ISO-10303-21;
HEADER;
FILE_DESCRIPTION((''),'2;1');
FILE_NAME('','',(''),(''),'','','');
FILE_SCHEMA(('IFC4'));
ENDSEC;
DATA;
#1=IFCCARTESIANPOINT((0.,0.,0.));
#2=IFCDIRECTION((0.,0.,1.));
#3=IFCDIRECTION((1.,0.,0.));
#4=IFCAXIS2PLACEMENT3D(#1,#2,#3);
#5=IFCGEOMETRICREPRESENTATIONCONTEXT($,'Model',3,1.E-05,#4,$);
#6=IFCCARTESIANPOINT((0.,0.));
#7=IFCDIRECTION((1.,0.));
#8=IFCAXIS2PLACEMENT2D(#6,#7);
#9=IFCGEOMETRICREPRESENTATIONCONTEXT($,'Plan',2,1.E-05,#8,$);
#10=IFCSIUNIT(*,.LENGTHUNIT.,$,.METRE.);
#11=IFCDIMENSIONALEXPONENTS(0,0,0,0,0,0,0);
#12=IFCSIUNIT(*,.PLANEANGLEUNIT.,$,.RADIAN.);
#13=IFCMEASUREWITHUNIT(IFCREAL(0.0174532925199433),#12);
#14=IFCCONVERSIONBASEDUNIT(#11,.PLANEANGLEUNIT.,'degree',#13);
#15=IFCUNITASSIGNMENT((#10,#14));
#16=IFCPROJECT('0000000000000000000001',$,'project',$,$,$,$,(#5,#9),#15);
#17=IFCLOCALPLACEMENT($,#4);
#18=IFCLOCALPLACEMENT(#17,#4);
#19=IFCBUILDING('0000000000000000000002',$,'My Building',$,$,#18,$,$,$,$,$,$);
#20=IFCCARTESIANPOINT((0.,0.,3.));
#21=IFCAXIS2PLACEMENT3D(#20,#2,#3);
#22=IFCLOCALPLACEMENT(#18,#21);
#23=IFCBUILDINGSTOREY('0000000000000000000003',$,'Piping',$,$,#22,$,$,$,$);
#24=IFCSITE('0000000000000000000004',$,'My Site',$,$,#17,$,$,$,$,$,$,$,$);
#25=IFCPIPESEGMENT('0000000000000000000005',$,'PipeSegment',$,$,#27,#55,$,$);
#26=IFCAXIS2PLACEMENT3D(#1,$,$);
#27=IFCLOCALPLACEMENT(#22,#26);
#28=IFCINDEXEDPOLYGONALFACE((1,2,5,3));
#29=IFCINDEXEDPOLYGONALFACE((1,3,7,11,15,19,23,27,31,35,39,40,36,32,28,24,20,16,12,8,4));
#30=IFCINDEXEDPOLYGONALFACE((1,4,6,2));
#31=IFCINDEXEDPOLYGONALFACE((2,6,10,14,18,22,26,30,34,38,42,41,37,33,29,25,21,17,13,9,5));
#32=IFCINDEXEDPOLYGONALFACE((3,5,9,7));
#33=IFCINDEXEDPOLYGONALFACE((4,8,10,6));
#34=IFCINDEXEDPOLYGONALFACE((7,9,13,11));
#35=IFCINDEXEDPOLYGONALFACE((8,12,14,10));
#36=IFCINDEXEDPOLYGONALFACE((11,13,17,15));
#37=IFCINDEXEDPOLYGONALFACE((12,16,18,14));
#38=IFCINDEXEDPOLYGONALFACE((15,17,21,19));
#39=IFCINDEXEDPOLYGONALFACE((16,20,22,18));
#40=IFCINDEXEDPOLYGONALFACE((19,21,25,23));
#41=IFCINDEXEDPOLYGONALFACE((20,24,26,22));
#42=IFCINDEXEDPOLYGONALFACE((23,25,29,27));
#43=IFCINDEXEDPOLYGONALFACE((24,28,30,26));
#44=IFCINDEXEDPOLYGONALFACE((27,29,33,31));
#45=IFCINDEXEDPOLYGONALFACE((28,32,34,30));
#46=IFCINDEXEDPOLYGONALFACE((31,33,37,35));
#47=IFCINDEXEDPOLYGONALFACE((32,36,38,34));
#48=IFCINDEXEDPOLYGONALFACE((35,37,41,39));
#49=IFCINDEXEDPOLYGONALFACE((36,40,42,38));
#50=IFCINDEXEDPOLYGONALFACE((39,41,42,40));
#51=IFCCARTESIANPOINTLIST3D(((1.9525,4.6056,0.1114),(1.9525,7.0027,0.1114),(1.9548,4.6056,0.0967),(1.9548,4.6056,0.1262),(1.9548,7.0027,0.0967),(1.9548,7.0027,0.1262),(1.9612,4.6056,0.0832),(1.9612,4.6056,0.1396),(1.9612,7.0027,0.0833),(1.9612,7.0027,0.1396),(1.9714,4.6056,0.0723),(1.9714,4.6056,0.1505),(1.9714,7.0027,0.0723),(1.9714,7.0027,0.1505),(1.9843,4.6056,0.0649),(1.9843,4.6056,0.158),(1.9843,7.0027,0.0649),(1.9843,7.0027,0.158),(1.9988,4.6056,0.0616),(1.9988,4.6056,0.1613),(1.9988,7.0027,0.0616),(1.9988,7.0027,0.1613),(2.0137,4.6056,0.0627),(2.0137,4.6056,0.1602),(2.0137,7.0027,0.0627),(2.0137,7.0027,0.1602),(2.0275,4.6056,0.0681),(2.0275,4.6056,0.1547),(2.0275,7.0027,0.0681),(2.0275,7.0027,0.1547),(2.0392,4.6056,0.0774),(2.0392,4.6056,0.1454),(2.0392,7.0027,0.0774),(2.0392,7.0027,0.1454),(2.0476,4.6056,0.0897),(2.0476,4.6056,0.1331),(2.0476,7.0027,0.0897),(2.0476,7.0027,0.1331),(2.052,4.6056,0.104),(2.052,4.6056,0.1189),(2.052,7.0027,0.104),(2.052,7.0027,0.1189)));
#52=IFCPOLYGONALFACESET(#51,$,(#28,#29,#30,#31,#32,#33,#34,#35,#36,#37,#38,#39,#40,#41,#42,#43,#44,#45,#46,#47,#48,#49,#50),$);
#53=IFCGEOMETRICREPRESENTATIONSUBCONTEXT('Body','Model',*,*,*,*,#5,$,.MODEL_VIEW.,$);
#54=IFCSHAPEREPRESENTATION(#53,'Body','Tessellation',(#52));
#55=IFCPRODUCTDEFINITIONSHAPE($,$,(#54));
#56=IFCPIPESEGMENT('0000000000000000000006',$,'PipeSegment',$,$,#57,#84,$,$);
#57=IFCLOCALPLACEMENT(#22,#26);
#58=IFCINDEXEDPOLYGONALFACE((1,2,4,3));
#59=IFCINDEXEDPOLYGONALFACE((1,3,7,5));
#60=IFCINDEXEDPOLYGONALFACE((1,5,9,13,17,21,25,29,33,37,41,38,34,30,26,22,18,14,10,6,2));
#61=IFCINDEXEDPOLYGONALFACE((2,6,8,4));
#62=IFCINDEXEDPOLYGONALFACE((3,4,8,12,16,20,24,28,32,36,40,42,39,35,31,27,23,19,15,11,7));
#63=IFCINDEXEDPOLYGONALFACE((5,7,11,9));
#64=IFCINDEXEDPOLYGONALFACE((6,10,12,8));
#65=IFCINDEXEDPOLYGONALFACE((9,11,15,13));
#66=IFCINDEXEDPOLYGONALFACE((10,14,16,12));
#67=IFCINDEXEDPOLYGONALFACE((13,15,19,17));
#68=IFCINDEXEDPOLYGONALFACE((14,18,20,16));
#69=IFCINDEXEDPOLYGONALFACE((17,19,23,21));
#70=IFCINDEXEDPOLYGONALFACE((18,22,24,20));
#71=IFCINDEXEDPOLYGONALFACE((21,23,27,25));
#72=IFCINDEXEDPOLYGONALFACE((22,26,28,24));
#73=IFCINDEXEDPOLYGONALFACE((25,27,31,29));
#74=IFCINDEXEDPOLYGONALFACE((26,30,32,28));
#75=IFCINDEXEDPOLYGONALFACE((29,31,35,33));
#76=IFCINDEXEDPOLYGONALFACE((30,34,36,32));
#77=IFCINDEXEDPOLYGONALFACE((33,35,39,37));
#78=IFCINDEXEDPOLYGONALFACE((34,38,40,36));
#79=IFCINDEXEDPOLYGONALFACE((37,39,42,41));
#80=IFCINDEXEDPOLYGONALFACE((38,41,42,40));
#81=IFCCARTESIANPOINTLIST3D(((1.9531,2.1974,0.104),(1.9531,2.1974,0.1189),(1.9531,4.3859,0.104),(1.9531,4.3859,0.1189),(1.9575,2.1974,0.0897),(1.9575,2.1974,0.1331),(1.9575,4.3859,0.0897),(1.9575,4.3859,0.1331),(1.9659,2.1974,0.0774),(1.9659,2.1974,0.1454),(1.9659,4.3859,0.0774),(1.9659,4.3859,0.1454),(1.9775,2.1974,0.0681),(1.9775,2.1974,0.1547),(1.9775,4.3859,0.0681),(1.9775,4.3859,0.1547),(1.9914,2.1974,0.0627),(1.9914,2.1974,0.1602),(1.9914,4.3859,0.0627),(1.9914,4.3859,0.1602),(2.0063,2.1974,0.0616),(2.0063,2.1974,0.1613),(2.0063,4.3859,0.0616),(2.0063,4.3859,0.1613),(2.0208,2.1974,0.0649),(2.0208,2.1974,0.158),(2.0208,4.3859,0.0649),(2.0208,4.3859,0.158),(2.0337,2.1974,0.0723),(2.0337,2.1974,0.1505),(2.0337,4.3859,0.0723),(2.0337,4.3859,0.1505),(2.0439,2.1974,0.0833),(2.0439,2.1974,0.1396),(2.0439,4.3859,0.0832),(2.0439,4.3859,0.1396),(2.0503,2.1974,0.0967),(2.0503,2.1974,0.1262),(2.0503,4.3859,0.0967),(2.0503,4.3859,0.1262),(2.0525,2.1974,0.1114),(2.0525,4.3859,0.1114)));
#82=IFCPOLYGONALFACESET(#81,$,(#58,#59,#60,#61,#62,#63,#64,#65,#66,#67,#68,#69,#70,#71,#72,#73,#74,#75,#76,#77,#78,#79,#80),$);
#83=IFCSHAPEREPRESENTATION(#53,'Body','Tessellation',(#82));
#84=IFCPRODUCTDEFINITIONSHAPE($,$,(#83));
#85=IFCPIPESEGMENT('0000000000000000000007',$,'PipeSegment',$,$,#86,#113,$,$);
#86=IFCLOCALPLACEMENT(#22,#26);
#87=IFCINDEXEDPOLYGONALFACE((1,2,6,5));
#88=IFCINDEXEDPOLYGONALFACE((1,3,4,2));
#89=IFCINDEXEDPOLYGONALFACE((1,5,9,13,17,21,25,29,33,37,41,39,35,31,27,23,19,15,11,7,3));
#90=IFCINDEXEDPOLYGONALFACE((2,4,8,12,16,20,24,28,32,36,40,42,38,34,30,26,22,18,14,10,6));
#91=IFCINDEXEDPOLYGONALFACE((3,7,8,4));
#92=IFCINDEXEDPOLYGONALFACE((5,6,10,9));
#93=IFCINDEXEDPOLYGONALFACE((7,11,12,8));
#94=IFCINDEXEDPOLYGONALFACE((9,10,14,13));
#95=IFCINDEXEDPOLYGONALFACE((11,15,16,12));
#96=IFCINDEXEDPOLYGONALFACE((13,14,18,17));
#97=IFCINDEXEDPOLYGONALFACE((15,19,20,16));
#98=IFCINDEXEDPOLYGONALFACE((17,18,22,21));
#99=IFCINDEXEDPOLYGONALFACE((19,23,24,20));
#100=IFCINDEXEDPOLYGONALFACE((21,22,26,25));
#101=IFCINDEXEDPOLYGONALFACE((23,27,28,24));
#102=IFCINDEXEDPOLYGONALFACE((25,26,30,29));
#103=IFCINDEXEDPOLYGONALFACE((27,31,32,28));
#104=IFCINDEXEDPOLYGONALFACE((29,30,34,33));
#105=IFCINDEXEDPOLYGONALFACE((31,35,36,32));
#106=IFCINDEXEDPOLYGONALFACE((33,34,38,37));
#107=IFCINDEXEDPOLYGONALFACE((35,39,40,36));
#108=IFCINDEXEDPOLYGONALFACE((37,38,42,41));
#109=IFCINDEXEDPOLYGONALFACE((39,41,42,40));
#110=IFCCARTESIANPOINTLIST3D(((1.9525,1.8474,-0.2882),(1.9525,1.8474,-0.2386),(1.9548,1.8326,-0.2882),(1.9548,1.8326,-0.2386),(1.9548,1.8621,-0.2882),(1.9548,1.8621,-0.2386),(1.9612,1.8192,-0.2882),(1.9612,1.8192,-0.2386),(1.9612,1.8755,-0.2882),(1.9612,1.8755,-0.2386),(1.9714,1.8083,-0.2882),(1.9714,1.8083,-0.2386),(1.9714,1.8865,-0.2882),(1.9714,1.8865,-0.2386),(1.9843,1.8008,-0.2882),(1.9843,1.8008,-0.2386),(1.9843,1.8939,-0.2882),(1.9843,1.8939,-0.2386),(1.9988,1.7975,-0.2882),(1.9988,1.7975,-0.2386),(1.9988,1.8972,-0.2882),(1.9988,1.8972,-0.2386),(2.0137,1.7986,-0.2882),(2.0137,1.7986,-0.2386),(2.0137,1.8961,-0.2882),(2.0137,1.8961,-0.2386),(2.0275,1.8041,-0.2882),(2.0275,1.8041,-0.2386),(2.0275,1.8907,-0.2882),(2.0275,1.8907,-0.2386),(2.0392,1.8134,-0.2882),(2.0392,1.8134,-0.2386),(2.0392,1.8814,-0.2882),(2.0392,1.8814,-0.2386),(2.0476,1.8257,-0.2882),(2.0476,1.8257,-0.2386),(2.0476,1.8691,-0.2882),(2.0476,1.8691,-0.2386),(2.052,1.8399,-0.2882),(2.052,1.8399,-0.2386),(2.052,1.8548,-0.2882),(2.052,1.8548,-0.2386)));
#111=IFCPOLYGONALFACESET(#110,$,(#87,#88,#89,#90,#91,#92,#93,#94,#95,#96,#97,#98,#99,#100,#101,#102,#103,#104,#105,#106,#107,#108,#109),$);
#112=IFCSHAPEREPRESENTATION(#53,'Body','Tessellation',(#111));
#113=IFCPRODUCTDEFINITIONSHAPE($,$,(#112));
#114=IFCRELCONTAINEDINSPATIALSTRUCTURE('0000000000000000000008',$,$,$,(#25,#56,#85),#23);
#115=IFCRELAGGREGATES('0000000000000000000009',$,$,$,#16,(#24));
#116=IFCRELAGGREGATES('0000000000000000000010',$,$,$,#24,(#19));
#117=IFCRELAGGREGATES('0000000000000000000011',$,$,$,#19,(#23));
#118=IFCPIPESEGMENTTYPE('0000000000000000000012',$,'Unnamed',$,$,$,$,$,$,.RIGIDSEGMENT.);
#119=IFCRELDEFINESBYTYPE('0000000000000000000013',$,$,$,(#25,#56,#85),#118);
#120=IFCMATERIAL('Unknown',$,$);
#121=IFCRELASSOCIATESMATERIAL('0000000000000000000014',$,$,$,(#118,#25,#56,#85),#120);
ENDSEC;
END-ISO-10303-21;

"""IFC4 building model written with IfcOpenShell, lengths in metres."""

from ifc_helpers import new_model, entity, si_unit, converted_unit, frame, origin_with_axes, origin_2d_with_axis, place, context, subcontext, project, spatial, circle, extrude, material, material_profile, profile_set, profile_usage, type_object, element, save


model = new_model("IFC4")

# Units and contexts
model_context = context("Model", 3, precision=1e-05, world=origin_with_axes())
plan_context = context("Plan", 2, precision=1e-05, world=origin_2d_with_axis())
body_context = subcontext(model_context, "Body", "Model", "MODEL_VIEW")
ifc_project = project(units=[si_unit("LENGTHUNIT", "METRE"), converted_unit("PLANEANGLEUNIT", "degree", entity("IfcReal", 0.0174532925199433), si_unit("PLANEANGLEUNIT", "RADIAN"), dimensions=[0, 0, 0, 0, 0, 0, 0])], contexts=[model_context, plan_context])

# Site, building, storey
site_placement = place(None, origin_with_axes())
site = spatial("IfcSite", under=ifc_project, at=site_placement, Name="My Site")
building_placement = place(site_placement, origin_with_axes())
building = spatial("IfcBuilding", under=site, at=building_placement, Name="My Building")
storey_placement = place(building_placement, frame((0.0, 0.0, 3.0), z_axis=(0.0, 0.0, 1.0), x_axis=(1.0, 0.0, 0.0)))
storey = spatial("IfcBuildingStorey", under=building, at=storey_placement, Name="Piping")

# Pipe segments
ifc_material = material(Name="Unknown")
ifc_material_profile_1 = material_profile(ifc_material, circle(Radius=0.05))
ifc_profile_set_1 = profile_set([ifc_material_profile_1])
pipe_segment_type = type_object("IfcPipeSegmentType", Name="Unnamed", PredefinedType="RIGIDSEGMENT", material=ifc_profile_set_1)
ifc_profile_usage_1 = profile_usage(ifc_profile_set_1, cardinal=16)
pipe_segment_1_placement = place(storey_placement, frame((2.0025, 4.6056, 0.1114), z_axis=(0.0, 1.0, 0.0), x_axis=(-1.0, 0.0, 0.0)))
element("IfcPipeSegment", 1, at=pipe_segment_1_placement, inside=storey, type_object=pipe_segment_type, material=ifc_profile_usage_1, Name="PipeSegment", context=body_context, shape_type="SweptSolid", body=[
    extrude(circle(Radius=0.05), origin_with_axes(), (0.0, 0.0, 1.0), 2.3972),
])
ifc_profile_usage_2 = profile_usage(ifc_profile_set_1, cardinal=16)
pipe_segment_2_placement = place(storey_placement, frame((2.0025, 4.3859, 0.1114), z_axis=(0.0, -1.0, 0.0), x_axis=(1.0, 0.0, 0.0)))
element("IfcPipeSegment", 2, at=pipe_segment_2_placement, inside=storey, type_object=pipe_segment_type, material=ifc_profile_usage_2, Name="PipeSegment", context=body_context, shape_type="SweptSolid", body=[
    extrude(circle(Radius=0.05), origin_with_axes(), (0.0, 0.0, 1.0), 2.1885),
])
ifc_profile_usage_3 = profile_usage(ifc_profile_set_1, cardinal=16)
pipe_segment_3_placement = place(storey_placement, frame((2.0025, 1.8474, -0.2386), z_axis=(0.0, 0.0, -1.0), x_axis=(-1.0, 0.0, 0.0)))
element("IfcPipeSegment", 3, at=pipe_segment_3_placement, inside=storey, type_object=pipe_segment_type, material=ifc_profile_usage_3, Name="PipeSegment", context=body_context, shape_type="SweptSolid", body=[
    extrude(circle(Radius=0.05), origin_with_axes(), (0.0, 0.0, 1.0), 0.0496),
])

save(model, "model.ifc")
